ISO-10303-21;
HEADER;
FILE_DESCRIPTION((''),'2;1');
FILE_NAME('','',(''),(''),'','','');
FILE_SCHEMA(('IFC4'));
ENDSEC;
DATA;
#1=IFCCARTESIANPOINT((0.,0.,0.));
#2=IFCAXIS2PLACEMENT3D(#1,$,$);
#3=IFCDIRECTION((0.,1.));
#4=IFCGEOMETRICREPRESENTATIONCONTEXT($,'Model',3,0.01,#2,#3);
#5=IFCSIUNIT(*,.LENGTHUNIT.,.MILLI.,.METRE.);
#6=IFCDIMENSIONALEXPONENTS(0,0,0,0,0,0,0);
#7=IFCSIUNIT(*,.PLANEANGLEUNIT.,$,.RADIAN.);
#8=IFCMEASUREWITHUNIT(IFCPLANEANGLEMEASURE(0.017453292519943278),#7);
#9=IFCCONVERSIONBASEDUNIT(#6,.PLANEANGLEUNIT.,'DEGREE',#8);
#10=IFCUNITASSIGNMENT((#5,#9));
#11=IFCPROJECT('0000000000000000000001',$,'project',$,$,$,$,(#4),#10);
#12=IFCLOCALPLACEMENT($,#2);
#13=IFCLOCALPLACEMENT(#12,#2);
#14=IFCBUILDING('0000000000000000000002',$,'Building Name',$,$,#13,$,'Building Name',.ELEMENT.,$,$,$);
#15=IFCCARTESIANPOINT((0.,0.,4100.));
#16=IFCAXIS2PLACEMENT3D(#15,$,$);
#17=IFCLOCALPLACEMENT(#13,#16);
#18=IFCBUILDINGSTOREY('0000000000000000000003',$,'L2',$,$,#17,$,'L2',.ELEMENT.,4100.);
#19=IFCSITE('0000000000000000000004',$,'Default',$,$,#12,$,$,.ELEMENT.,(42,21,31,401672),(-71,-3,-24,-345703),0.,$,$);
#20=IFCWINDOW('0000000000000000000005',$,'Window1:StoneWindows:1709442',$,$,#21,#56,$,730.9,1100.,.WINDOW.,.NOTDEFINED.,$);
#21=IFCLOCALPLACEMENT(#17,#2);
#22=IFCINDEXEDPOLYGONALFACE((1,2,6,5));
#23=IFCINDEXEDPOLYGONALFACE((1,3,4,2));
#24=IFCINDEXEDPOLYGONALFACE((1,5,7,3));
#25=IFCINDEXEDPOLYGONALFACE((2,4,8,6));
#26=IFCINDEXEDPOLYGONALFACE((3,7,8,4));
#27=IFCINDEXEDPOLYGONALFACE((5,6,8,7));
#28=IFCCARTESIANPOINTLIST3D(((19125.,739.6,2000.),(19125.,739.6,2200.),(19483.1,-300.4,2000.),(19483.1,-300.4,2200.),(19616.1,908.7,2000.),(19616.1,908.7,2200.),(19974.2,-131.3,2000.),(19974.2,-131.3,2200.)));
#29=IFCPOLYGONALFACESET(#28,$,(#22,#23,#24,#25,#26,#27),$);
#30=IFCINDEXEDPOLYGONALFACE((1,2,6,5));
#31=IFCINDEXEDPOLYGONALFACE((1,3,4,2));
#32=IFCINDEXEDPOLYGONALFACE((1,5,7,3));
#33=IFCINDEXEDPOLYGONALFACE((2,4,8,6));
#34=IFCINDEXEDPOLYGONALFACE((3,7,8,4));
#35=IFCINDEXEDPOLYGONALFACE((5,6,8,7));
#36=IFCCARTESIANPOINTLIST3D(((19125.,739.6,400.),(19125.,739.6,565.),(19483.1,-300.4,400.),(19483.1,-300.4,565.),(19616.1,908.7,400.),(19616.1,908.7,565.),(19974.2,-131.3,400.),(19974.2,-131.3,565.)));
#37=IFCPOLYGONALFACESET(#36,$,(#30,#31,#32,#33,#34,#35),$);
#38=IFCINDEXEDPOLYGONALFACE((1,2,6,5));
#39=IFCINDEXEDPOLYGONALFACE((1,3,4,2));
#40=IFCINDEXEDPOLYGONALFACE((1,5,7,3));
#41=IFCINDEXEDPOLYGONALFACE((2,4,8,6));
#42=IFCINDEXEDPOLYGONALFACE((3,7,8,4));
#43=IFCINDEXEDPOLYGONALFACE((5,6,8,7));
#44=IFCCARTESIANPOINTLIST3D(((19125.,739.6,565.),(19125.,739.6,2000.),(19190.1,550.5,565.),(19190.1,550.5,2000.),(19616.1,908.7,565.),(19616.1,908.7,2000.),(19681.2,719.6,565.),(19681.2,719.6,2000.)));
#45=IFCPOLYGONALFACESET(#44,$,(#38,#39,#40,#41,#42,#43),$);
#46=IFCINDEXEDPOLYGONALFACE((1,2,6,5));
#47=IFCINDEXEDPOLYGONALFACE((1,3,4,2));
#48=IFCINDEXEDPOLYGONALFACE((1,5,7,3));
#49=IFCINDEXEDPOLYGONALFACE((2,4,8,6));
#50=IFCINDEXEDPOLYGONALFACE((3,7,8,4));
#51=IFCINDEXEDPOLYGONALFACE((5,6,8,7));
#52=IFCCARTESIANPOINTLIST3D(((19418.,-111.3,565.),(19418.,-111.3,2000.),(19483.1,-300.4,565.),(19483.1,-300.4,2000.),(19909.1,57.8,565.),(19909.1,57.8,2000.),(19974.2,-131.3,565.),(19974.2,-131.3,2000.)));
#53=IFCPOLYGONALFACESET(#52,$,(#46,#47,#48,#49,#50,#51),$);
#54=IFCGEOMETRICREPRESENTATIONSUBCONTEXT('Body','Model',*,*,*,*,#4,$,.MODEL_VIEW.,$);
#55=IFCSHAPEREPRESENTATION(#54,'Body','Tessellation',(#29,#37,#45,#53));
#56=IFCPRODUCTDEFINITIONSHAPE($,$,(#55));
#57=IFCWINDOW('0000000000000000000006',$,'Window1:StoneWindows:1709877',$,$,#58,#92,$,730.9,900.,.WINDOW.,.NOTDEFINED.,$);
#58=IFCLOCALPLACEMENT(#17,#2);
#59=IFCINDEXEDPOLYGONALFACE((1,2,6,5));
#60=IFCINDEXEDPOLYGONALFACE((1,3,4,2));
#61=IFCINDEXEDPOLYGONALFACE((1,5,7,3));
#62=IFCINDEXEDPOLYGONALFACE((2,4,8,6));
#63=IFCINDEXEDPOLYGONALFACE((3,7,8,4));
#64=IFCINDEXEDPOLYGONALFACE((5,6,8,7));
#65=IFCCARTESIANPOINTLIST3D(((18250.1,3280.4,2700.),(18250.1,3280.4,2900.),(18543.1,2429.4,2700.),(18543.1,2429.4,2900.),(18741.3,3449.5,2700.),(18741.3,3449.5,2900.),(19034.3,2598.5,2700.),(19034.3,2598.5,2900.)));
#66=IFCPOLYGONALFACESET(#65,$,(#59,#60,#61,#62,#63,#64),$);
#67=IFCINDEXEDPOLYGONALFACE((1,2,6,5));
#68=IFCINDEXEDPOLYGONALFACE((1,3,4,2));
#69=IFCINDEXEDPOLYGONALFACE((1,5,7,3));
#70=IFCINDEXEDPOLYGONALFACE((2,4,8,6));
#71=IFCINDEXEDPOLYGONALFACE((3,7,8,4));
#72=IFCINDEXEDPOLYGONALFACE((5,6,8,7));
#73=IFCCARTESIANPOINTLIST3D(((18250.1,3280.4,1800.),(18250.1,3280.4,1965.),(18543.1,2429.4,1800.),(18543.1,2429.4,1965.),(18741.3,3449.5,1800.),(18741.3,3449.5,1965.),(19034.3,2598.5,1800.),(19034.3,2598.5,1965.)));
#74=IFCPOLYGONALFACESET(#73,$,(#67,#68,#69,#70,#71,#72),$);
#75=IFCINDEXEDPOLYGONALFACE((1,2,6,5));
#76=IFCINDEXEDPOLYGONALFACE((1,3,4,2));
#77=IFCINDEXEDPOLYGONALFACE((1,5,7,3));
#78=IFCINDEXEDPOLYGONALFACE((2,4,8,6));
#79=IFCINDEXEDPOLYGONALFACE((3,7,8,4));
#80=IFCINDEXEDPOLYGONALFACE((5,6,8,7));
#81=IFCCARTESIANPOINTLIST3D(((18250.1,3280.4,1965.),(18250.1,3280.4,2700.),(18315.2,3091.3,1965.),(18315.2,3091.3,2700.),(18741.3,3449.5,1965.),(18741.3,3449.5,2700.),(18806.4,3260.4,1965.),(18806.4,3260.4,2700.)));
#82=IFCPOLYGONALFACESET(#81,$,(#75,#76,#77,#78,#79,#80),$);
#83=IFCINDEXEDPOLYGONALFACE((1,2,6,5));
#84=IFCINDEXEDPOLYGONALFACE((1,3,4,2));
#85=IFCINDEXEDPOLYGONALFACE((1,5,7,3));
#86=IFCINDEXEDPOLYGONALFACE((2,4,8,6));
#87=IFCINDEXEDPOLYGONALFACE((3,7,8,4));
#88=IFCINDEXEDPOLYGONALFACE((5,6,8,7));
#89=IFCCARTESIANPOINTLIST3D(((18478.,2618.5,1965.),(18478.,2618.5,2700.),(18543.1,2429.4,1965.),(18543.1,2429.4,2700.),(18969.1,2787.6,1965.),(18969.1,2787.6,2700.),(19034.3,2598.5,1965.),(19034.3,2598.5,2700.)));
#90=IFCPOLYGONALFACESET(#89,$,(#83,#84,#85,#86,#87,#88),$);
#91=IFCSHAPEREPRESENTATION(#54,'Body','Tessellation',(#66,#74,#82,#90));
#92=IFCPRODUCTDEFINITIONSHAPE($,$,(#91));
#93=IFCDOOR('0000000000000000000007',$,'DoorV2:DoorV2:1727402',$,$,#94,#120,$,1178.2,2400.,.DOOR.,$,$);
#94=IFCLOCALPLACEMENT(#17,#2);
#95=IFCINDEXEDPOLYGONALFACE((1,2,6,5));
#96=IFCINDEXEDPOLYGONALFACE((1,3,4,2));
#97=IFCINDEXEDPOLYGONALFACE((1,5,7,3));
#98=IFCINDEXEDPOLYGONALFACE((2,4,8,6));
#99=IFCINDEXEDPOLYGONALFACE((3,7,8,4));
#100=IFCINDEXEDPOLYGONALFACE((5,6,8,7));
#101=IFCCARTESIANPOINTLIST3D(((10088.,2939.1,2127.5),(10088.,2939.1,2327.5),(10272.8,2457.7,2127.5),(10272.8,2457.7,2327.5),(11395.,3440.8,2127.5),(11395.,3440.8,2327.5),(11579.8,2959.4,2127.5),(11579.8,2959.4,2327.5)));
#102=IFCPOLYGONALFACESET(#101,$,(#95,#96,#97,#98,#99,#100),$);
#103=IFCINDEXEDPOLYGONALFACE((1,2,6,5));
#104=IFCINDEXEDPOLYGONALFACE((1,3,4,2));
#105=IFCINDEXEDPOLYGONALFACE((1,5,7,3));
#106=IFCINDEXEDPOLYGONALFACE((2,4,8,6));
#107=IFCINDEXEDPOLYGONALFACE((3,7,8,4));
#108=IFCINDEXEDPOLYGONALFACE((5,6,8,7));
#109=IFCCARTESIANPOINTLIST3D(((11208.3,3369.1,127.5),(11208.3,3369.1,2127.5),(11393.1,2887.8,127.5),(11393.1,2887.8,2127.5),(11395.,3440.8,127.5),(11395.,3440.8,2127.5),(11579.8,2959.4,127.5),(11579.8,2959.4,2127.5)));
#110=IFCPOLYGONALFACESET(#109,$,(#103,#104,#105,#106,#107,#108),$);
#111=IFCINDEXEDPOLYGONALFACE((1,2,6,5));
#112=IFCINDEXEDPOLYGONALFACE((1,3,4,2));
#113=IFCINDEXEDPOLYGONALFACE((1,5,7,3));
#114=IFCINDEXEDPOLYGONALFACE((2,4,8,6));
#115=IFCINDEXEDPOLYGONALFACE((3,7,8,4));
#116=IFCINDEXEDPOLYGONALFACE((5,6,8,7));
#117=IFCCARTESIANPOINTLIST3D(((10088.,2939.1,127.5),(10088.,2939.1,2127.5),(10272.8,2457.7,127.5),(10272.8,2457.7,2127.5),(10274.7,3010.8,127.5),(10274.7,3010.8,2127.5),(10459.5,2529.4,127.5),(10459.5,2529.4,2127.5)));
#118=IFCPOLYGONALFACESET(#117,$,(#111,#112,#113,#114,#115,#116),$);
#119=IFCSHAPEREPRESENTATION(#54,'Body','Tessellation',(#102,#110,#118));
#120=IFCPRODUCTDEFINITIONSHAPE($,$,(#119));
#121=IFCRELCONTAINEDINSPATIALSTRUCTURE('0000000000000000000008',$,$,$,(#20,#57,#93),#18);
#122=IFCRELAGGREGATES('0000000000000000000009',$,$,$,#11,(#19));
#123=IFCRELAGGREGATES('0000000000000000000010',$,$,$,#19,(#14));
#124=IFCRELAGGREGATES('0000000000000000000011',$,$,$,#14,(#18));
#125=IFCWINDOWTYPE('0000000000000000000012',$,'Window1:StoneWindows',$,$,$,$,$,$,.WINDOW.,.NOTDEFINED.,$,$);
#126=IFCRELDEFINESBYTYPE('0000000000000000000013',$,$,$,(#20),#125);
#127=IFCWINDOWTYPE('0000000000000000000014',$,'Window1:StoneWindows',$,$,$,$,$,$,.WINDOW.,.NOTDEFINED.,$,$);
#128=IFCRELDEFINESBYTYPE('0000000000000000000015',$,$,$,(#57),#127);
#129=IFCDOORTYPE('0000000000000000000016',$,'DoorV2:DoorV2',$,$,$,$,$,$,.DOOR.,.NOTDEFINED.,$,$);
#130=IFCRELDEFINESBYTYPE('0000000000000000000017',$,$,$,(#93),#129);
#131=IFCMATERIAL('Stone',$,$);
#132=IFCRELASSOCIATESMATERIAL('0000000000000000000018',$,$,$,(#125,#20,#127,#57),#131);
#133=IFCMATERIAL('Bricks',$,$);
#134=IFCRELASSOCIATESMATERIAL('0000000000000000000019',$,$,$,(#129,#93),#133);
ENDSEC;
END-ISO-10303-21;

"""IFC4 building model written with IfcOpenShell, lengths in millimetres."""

from ifc_helpers import new_model, entity, si_unit, converted_unit, direction, frame, origin, place, context, subcontext, project, spatial, indexed_curve, outline, extrude, source, transform, mapped, material, type_object, type_shapes, element, save


model = new_model("IFC4")

# Units and contexts
model_context = context("Model", 3, precision=0.01, world=origin(), true_north=direction((0.0, 1.0)))
body_context = subcontext(model_context, "Body", "Model", "MODEL_VIEW")
ifc_project = project(units=[si_unit("LENGTHUNIT", "METRE", prefix="MILLI"), converted_unit("PLANEANGLEUNIT", "DEGREE", entity("IfcPlaneAngleMeasure", 0.017453292519943278), si_unit("PLANEANGLEUNIT", "RADIAN"), dimensions=[0, 0, 0, 0, 0, 0, 0])], contexts=[model_context])

# Site, building, storey
site_placement = place(None, origin())
site = spatial("IfcSite", under=ifc_project, at=site_placement, Name="Default", CompositionType="ELEMENT", RefLatitude=(42, 21, 31, 401672), RefLongitude=(-71, -3, -24, -345703), RefElevation=0.0)
building_placement = place(site_placement, origin())
building = spatial("IfcBuilding", under=site, at=building_placement, Name="Building Name", LongName="Building Name", CompositionType="ELEMENT")
storey_placement = place(building_placement, frame((0.0, 0.0, 4100.0)))
storey = spatial("IfcBuildingStorey", under=building, at=storey_placement, Name="L2", LongName="L2", CompositionType="ELEMENT", Elevation=4100.0)

# Shared definitions
ifc_material_1 = material(Name="Stone")

# Windows
window_type_1 = type_object("IfcWindowType", Name="Window1:StoneWindows", PartitioningType="NOTDEFINED", PredefinedType="WINDOW", material=ifc_material_1)
shared_shape_1 = source(origin(), body_context, "Body", "SweptSolid", [
    extrude(outline(indexed_curve([(-259.7, -550.0), (259.7, -550.0), (259.7, 550.0), (-259.7, 550.0), (-259.7, -550.0)], self_intersect=False)), frame((0.0, 0.0, 2400.0), z_axis=(0.0, 0.0, 1.0), x_axis=(0.0, 1.0, 0.0)), (0.0, 0.0, 1.0), 200.0),
    extrude(outline(indexed_curve([(-259.7, -550.0), (259.7, -550.0), (259.7, 550.0), (-259.7, 550.0), (-259.7, -550.0)], self_intersect=False)), frame((0.0, 0.0, 800.0), z_axis=(0.0, 0.0, 1.0), x_axis=(0.0, 1.0, 0.0)), (0.0, 0.0, 1.0), 165.0),
    extrude(outline(indexed_curve([(-259.7, -100.0), (259.7, -100.0), (259.7, 100.0), (-259.7, 100.0), (-259.7, -100.0)], self_intersect=False)), frame((-450.0, 0.0, 965.0), z_axis=(0.0, 0.0, 1.0), x_axis=(0.0, 1.0, 0.0)), (0.0, 0.0, 1.0), 1435.0),
    extrude(outline(indexed_curve([(-259.7, -100.0), (259.7, -100.0), (259.7, 100.0), (-259.7, 100.0), (-259.7, -100.0)], self_intersect=False)), frame((450.0, 0.0, 965.0), z_axis=(0.0, 0.0, 1.0), x_axis=(0.0, 1.0, 0.0)), (0.0, 0.0, 1.0), 1435.0),
])
type_shapes(window_type_1, [shared_shape_1])
for number, where, z_axis, x_axis, name in (
    (1, (19549.6, 304.2, -400.0), (0.0, 0.0, 1.0), (0.325568, -0.945519, 0.0), "Window1:StoneWindows:1709442"),
):
    element("IfcWindow", number, at=place(storey_placement, frame(where, z_axis=z_axis, x_axis=x_axis)), inside=storey, type_object=window_type_1, material=ifc_material_1, Name=name, OverallHeight=730.9, OverallWidth=1100.0, PartitioningType="NOTDEFINED", PredefinedType="WINDOW", context=body_context, shape_type="MappedRepresentation", body=[
        mapped(shared_shape_1, transform((0.0, 0.0, 0.0), scale=1.0)),
    ])
window_type_2 = type_object("IfcWindowType", Name="Window1:StoneWindows", PartitioningType="NOTDEFINED", PredefinedType="WINDOW", material=ifc_material_1)
shared_shape_2 = source(origin(), body_context, "Body", "SweptSolid", [
    extrude(outline(indexed_curve([(-259.7, -450.0), (259.7, -450.0), (259.7, 450.0), (-259.7, 450.0), (-259.7, -450.0)], self_intersect=False)), frame((0.0, 0.0, 1700.0), z_axis=(0.0, 0.0, 1.0), x_axis=(0.0, 1.0, 0.0)), (0.0, 0.0, 1.0), 200.0),
    extrude(outline(indexed_curve([(-259.7, -450.0), (259.7, -450.0), (259.7, 450.0), (-259.7, 450.0), (-259.7, -450.0)], self_intersect=False)), frame((0.0, 0.0, 800.0), z_axis=(0.0, 0.0, 1.0), x_axis=(0.0, 1.0, 0.0)), (0.0, 0.0, 1.0), 165.0),
    extrude(outline(indexed_curve([(-259.7, -100.0), (259.7, -100.0), (259.7, 100.0), (-259.7, 100.0), (-259.7, -100.0)], self_intersect=False)), frame((-350.0, 0.0, 965.0), z_axis=(0.0, 0.0, 1.0), x_axis=(0.0, 1.0, 0.0)), (0.0, 0.0, 1.0), 735.0),
    extrude(outline(indexed_curve([(-259.7, -100.0), (259.7, -100.0), (259.7, 100.0), (-259.7, 100.0), (-259.7, -100.0)], self_intersect=False)), frame((350.0, 0.0, 965.0), z_axis=(0.0, 0.0, 1.0), x_axis=(0.0, 1.0, 0.0)), (0.0, 0.0, 1.0), 735.0),
])
type_shapes(window_type_2, [shared_shape_2])
window_1_placement = place(storey_placement, frame((18642.2, 2939.5, 1000.0), z_axis=(0.0, 0.0, 1.0), x_axis=(0.325568, -0.945519, 0.0)))
element("IfcWindow", 2, at=window_1_placement, inside=storey, type_object=window_type_2, material=ifc_material_1, Name="Window1:StoneWindows:1709877", OverallHeight=730.9, OverallWidth=900.0, PartitioningType="NOTDEFINED", PredefinedType="WINDOW", context=body_context, shape_type="MappedRepresentation", body=[
    mapped(shared_shape_2, transform((0.0, 0.0, 0.0), scale=1.0)),
])

# Door
ifc_material_2 = material(Name="Bricks")
door_type = type_object("IfcDoorType", Name="DoorV2:DoorV2", OperationType="NOTDEFINED", PredefinedType="DOOR", material=ifc_material_2)
shared_shape_3 = source(origin(), body_context, "Body", "SweptSolid", [
    extrude(outline(indexed_curve([(-257.8, -700.0), (257.8, -700.0), (257.8, 700.0), (-257.8, 700.0), (-257.8, -700.0)], self_intersect=False)), frame((0.0, 0.0, 2000.0), z_axis=(0.0, 0.0, 1.0), x_axis=(0.0, 1.0, 0.0)), (0.0, 0.0, 1.0), 200.0),
    extrude(outline(indexed_curve([(-257.8, -100.0), (257.8, -100.0), (257.8, 100.0), (-257.8, 100.0), (-257.8, -100.0)], self_intersect=False)), frame((600.0, 0.0, 0.0), z_axis=(0.0, 0.0, 1.0), x_axis=(0.0, 1.0, 0.0)), (0.0, 0.0, 1.0), 2000.0),
    extrude(outline(indexed_curve([(-257.8, -100.0), (257.8, -100.0), (257.8, 100.0), (-257.8, 100.0), (-257.8, -100.0)], self_intersect=False)), frame((-600.0, 0.0, 0.0), z_axis=(0.0, 0.0, 1.0), x_axis=(0.0, 1.0, 0.0)), (0.0, 0.0, 1.0), 2000.0),
])
type_shapes(door_type, [shared_shape_3])
door_placement = place(storey_placement, frame((10833.9, 2949.3, 127.5), z_axis=(0.0, 0.0, 1.0), x_axis=(0.93358, 0.358368, 0.0)))
element("IfcDoor", 3, at=door_placement, inside=storey, type_object=door_type, material=ifc_material_2, Name="DoorV2:DoorV2:1727402", OverallHeight=1178.2, OverallWidth=2400.0, PredefinedType="DOOR", context=body_context, shape_type="MappedRepresentation", body=[
    mapped(shared_shape_3, transform((0.0, 0.0, 0.0), scale=1.0)),
])

save(model, "model.ifc")
